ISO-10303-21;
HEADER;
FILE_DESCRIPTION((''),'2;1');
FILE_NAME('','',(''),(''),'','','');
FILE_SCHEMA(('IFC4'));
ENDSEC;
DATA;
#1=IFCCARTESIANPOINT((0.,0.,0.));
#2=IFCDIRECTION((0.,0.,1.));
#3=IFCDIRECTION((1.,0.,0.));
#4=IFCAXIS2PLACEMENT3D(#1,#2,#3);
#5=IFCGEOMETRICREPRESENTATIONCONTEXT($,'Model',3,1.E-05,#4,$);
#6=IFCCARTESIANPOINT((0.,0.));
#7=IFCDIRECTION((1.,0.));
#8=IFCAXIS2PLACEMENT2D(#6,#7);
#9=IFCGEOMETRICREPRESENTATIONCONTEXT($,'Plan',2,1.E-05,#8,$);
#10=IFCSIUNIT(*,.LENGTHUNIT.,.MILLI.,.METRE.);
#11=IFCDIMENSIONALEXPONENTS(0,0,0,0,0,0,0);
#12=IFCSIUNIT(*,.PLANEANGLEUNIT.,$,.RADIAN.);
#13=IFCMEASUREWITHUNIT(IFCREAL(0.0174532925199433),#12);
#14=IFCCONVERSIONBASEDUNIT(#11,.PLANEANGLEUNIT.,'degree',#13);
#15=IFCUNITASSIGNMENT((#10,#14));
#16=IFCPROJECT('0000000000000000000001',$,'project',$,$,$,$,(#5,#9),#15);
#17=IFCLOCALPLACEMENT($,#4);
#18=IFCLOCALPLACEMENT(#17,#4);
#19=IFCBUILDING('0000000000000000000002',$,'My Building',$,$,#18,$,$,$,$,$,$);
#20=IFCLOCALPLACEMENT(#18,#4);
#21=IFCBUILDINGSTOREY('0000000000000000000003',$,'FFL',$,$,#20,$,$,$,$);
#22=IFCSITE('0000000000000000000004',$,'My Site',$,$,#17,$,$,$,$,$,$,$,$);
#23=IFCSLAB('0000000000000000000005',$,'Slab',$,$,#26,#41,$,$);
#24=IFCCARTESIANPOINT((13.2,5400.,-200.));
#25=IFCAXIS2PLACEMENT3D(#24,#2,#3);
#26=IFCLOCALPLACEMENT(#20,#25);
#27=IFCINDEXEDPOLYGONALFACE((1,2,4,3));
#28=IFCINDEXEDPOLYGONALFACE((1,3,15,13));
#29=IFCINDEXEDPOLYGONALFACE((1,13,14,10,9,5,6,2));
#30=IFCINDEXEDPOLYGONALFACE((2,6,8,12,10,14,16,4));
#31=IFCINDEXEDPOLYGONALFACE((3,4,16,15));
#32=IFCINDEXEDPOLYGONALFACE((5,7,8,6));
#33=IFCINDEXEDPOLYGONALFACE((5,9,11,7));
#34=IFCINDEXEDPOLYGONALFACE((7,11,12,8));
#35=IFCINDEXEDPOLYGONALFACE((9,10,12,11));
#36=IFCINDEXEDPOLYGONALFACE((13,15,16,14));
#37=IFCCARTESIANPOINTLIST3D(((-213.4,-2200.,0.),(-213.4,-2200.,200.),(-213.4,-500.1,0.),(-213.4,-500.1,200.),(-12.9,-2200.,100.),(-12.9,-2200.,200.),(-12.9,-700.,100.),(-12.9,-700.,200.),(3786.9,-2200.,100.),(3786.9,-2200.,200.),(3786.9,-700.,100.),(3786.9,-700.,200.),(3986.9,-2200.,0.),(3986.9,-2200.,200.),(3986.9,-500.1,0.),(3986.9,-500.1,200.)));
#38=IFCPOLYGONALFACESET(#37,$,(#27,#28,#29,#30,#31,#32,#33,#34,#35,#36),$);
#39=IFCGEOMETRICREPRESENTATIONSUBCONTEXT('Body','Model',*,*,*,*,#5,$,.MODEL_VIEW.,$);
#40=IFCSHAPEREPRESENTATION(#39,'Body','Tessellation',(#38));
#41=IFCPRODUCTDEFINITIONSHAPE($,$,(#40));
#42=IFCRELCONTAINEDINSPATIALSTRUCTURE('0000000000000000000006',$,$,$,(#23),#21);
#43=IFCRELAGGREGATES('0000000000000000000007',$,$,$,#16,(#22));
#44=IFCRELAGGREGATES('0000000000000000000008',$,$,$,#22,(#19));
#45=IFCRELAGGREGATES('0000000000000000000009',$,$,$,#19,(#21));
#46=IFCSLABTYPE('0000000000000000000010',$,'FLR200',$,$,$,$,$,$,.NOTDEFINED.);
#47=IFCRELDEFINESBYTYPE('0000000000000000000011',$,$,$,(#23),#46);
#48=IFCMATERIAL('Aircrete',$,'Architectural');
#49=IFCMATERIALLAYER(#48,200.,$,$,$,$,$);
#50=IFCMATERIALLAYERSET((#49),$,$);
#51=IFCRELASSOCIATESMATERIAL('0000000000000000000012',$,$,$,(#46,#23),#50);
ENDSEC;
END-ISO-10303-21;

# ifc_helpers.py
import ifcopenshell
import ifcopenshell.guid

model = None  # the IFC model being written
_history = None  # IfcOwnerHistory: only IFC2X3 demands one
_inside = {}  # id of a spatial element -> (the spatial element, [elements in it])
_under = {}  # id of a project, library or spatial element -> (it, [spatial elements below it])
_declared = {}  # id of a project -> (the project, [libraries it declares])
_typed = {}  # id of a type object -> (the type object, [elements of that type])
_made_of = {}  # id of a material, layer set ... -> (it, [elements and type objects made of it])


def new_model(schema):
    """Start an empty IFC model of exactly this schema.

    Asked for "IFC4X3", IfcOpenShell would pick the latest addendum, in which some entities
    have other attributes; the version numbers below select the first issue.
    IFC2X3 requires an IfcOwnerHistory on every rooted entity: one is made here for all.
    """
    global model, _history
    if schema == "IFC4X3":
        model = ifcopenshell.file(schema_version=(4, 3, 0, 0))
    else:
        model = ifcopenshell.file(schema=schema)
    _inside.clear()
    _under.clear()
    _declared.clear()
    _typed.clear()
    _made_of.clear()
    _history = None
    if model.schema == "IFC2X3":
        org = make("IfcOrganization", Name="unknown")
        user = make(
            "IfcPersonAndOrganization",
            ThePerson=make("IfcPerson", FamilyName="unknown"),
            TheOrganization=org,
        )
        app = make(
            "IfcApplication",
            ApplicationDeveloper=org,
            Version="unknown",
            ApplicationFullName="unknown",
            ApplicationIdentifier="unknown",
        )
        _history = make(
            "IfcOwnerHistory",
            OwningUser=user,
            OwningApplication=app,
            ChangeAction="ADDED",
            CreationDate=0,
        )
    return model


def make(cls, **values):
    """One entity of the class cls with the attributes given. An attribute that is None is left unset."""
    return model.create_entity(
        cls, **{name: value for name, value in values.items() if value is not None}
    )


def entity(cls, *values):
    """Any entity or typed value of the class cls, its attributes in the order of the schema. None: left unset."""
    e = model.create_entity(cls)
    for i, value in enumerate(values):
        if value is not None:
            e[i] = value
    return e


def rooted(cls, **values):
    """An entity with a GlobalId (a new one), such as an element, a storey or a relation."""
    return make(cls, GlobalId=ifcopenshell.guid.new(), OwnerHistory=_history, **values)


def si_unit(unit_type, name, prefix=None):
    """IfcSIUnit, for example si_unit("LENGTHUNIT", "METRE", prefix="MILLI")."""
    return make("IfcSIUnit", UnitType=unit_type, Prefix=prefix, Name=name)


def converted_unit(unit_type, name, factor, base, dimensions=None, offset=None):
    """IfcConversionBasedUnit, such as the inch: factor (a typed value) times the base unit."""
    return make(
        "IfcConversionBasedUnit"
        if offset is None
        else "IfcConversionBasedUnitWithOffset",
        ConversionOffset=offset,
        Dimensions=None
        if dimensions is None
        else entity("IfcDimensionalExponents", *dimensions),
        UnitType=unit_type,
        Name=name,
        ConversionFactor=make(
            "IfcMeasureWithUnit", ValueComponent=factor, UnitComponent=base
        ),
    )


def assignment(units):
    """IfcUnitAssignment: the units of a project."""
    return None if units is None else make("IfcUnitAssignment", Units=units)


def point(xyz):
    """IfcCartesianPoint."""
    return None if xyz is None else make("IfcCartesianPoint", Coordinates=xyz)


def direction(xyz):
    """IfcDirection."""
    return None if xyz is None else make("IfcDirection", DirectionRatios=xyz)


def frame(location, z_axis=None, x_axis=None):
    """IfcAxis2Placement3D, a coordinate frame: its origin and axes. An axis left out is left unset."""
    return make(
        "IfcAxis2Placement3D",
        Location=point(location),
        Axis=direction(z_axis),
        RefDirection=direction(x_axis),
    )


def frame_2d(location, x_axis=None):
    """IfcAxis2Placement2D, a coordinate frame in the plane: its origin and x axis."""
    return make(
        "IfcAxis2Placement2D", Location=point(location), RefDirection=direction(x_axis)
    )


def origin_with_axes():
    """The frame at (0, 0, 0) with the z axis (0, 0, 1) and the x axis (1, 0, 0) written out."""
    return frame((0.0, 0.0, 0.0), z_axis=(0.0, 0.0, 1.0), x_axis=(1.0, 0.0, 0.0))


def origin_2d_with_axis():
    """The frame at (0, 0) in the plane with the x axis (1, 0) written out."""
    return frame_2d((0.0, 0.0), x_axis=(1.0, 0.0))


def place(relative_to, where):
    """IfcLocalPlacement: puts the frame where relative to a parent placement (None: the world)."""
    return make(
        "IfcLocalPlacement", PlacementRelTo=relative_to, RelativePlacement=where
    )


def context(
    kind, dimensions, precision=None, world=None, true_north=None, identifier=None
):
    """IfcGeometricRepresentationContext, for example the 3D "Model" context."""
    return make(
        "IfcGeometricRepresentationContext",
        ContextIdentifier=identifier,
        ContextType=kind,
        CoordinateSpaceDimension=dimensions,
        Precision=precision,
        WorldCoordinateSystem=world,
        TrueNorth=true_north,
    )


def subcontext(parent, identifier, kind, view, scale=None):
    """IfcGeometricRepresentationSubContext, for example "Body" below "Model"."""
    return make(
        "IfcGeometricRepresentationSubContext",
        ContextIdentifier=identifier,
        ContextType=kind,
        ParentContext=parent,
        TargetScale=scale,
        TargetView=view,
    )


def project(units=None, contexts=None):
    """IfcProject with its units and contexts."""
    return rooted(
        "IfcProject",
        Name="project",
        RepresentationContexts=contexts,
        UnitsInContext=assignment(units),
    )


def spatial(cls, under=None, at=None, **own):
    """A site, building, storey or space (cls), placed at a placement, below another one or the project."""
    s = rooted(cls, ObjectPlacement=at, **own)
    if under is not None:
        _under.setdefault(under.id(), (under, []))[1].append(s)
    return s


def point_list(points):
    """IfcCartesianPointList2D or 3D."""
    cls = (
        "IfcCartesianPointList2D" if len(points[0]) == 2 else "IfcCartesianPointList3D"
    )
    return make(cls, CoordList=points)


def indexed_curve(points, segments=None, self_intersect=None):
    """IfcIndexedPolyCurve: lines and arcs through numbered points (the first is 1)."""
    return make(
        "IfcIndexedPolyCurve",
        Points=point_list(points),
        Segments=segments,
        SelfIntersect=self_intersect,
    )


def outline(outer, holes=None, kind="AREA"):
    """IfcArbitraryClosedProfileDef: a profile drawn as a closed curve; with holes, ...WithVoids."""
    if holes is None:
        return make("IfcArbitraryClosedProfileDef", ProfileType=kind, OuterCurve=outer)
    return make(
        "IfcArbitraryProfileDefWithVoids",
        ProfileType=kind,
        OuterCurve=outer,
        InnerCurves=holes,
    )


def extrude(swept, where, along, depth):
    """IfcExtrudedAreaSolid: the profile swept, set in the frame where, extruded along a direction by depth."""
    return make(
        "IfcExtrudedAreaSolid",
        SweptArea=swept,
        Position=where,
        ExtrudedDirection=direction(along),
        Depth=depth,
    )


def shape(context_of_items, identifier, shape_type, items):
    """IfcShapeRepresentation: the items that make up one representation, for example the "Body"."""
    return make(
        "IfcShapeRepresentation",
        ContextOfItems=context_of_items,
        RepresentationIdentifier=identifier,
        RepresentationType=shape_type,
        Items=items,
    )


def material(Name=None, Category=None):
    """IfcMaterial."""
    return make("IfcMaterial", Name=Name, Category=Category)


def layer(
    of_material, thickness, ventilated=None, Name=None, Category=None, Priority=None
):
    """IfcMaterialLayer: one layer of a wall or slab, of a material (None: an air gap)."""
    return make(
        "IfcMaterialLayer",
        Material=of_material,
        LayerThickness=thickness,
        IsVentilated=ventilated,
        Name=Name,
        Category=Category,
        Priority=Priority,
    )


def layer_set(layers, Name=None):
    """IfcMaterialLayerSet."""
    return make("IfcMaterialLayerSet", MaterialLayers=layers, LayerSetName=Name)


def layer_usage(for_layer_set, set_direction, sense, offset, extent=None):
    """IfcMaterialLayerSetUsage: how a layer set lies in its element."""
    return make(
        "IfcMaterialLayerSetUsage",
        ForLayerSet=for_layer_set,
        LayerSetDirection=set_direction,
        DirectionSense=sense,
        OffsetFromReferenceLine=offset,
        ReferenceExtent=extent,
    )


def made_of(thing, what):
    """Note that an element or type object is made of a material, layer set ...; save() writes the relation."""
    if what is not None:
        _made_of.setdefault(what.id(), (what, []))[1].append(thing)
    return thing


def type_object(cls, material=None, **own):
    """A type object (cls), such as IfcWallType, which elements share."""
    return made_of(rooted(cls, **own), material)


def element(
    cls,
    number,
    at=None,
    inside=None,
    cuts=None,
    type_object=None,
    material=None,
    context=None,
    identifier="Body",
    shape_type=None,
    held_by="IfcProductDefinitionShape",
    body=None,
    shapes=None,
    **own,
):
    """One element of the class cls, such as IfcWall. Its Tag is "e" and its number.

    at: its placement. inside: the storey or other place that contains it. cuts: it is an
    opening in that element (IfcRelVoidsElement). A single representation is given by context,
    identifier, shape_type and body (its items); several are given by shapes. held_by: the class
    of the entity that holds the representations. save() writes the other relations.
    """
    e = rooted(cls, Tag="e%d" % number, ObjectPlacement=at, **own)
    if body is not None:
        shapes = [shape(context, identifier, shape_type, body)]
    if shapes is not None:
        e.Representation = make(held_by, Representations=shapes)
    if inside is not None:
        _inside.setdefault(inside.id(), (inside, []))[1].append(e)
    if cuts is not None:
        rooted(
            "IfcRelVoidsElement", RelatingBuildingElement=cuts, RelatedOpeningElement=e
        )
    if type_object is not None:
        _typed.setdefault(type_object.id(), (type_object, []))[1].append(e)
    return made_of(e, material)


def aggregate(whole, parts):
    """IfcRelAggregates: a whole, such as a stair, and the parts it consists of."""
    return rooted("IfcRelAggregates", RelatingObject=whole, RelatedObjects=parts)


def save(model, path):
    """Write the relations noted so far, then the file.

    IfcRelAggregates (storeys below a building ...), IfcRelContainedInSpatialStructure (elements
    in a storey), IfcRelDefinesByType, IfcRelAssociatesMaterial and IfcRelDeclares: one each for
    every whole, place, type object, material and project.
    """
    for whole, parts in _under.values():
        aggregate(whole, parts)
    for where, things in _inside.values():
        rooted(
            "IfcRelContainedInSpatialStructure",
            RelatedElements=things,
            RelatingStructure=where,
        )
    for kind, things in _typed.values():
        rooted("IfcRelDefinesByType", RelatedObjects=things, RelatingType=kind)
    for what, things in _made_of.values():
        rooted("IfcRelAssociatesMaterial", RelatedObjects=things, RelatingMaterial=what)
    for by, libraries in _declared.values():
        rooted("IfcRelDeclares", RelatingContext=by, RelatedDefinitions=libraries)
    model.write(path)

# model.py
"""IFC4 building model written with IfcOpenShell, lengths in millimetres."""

from ifc_helpers import new_model, entity, si_unit, converted_unit, frame, origin_with_axes, origin_2d_with_axis, place, context, subcontext, project, spatial, indexed_curve, outline, extrude, material, layer, layer_set, layer_usage, type_object, element, save


model = new_model("IFC4")

# Units and contexts
model_context = context("Model", 3, precision=1e-05, world=origin_with_axes())
plan_context = context("Plan", 2, precision=1e-05, world=origin_2d_with_axis())
body_context_1 = subcontext(model_context, "Body", "Model", "MODEL_VIEW")
ifc_project = project(units=[si_unit("LENGTHUNIT", "METRE", prefix="MILLI"), converted_unit("PLANEANGLEUNIT", "degree", entity("IfcReal", 0.0174532925199433), si_unit("PLANEANGLEUNIT", "RADIAN"), dimensions=[0, 0, 0, 0, 0, 0, 0])], contexts=[model_context, plan_context])

# Site, building, storey
site_placement = place(None, origin_with_axes())
site = spatial("IfcSite", under=ifc_project, at=site_placement, Name="My Site")
building_placement = place(site_placement, origin_with_axes())
building = spatial("IfcBuilding", under=site, at=building_placement, Name="My Building")
storey_placement = place(building_placement, origin_with_axes())
storey = spatial("IfcBuildingStorey", under=building, at=storey_placement, Name="FFL")

# Slab, opening
ifc_material_1 = material(Name="Aircrete", Category="Architectural")
ifc_layer_1 = layer(ifc_material_1, 200.0)
ifc_layer_set_1 = layer_set([ifc_layer_1])
ifc_layer_usage_1 = layer_usage(ifc_layer_set_1, "AXIS3", "POSITIVE", 0.0)
slab_type = type_object("IfcSlabType", Name="FLR200", PredefinedType="NOTDEFINED", material=ifc_layer_set_1)
slab_placement = place(storey_placement, frame((13.2, 5400.0, -200.0), z_axis=(0.0, 0.0, 1.0), x_axis=(1.0, 0.0, 0.0)))
slab = element("IfcSlab", 1, at=slab_placement, inside=storey, type_object=slab_type, material=ifc_layer_usage_1, Name="Slab", context=body_context_1, shape_type="SweptSolid", body=[
    extrude(outline(indexed_curve([(-213.4, -500.1), (3986.9, -500.1), (3986.9, -2200.0), (-213.4, -2200.0), (-213.4, -500.1)])), None, (0.0, 0.0, 1.0), 200.0),
])
opening_1_placement = place(slab_placement, frame((3787.1, -2000.0, 100.0), z_axis=(0.0, 0.0, 1.0), x_axis=(0.0, 1.0, 0.0)))
element("IfcOpeningElement", 2, at=opening_1_placement, cuts=slab, PredefinedType="OPENING", context=body_context_1, shape_type="SweptSolid", body=[
    extrude(outline(indexed_curve([(-200.0, 3800.0), (1300.0, 3800.0), (1300.0, 0.2), (-200.0, 0.2), (-200.0, 3800.0)])), origin_with_axes(), (0.0, 0.0, 1.0), 500.0),
])

save(model, "model.ifc")
